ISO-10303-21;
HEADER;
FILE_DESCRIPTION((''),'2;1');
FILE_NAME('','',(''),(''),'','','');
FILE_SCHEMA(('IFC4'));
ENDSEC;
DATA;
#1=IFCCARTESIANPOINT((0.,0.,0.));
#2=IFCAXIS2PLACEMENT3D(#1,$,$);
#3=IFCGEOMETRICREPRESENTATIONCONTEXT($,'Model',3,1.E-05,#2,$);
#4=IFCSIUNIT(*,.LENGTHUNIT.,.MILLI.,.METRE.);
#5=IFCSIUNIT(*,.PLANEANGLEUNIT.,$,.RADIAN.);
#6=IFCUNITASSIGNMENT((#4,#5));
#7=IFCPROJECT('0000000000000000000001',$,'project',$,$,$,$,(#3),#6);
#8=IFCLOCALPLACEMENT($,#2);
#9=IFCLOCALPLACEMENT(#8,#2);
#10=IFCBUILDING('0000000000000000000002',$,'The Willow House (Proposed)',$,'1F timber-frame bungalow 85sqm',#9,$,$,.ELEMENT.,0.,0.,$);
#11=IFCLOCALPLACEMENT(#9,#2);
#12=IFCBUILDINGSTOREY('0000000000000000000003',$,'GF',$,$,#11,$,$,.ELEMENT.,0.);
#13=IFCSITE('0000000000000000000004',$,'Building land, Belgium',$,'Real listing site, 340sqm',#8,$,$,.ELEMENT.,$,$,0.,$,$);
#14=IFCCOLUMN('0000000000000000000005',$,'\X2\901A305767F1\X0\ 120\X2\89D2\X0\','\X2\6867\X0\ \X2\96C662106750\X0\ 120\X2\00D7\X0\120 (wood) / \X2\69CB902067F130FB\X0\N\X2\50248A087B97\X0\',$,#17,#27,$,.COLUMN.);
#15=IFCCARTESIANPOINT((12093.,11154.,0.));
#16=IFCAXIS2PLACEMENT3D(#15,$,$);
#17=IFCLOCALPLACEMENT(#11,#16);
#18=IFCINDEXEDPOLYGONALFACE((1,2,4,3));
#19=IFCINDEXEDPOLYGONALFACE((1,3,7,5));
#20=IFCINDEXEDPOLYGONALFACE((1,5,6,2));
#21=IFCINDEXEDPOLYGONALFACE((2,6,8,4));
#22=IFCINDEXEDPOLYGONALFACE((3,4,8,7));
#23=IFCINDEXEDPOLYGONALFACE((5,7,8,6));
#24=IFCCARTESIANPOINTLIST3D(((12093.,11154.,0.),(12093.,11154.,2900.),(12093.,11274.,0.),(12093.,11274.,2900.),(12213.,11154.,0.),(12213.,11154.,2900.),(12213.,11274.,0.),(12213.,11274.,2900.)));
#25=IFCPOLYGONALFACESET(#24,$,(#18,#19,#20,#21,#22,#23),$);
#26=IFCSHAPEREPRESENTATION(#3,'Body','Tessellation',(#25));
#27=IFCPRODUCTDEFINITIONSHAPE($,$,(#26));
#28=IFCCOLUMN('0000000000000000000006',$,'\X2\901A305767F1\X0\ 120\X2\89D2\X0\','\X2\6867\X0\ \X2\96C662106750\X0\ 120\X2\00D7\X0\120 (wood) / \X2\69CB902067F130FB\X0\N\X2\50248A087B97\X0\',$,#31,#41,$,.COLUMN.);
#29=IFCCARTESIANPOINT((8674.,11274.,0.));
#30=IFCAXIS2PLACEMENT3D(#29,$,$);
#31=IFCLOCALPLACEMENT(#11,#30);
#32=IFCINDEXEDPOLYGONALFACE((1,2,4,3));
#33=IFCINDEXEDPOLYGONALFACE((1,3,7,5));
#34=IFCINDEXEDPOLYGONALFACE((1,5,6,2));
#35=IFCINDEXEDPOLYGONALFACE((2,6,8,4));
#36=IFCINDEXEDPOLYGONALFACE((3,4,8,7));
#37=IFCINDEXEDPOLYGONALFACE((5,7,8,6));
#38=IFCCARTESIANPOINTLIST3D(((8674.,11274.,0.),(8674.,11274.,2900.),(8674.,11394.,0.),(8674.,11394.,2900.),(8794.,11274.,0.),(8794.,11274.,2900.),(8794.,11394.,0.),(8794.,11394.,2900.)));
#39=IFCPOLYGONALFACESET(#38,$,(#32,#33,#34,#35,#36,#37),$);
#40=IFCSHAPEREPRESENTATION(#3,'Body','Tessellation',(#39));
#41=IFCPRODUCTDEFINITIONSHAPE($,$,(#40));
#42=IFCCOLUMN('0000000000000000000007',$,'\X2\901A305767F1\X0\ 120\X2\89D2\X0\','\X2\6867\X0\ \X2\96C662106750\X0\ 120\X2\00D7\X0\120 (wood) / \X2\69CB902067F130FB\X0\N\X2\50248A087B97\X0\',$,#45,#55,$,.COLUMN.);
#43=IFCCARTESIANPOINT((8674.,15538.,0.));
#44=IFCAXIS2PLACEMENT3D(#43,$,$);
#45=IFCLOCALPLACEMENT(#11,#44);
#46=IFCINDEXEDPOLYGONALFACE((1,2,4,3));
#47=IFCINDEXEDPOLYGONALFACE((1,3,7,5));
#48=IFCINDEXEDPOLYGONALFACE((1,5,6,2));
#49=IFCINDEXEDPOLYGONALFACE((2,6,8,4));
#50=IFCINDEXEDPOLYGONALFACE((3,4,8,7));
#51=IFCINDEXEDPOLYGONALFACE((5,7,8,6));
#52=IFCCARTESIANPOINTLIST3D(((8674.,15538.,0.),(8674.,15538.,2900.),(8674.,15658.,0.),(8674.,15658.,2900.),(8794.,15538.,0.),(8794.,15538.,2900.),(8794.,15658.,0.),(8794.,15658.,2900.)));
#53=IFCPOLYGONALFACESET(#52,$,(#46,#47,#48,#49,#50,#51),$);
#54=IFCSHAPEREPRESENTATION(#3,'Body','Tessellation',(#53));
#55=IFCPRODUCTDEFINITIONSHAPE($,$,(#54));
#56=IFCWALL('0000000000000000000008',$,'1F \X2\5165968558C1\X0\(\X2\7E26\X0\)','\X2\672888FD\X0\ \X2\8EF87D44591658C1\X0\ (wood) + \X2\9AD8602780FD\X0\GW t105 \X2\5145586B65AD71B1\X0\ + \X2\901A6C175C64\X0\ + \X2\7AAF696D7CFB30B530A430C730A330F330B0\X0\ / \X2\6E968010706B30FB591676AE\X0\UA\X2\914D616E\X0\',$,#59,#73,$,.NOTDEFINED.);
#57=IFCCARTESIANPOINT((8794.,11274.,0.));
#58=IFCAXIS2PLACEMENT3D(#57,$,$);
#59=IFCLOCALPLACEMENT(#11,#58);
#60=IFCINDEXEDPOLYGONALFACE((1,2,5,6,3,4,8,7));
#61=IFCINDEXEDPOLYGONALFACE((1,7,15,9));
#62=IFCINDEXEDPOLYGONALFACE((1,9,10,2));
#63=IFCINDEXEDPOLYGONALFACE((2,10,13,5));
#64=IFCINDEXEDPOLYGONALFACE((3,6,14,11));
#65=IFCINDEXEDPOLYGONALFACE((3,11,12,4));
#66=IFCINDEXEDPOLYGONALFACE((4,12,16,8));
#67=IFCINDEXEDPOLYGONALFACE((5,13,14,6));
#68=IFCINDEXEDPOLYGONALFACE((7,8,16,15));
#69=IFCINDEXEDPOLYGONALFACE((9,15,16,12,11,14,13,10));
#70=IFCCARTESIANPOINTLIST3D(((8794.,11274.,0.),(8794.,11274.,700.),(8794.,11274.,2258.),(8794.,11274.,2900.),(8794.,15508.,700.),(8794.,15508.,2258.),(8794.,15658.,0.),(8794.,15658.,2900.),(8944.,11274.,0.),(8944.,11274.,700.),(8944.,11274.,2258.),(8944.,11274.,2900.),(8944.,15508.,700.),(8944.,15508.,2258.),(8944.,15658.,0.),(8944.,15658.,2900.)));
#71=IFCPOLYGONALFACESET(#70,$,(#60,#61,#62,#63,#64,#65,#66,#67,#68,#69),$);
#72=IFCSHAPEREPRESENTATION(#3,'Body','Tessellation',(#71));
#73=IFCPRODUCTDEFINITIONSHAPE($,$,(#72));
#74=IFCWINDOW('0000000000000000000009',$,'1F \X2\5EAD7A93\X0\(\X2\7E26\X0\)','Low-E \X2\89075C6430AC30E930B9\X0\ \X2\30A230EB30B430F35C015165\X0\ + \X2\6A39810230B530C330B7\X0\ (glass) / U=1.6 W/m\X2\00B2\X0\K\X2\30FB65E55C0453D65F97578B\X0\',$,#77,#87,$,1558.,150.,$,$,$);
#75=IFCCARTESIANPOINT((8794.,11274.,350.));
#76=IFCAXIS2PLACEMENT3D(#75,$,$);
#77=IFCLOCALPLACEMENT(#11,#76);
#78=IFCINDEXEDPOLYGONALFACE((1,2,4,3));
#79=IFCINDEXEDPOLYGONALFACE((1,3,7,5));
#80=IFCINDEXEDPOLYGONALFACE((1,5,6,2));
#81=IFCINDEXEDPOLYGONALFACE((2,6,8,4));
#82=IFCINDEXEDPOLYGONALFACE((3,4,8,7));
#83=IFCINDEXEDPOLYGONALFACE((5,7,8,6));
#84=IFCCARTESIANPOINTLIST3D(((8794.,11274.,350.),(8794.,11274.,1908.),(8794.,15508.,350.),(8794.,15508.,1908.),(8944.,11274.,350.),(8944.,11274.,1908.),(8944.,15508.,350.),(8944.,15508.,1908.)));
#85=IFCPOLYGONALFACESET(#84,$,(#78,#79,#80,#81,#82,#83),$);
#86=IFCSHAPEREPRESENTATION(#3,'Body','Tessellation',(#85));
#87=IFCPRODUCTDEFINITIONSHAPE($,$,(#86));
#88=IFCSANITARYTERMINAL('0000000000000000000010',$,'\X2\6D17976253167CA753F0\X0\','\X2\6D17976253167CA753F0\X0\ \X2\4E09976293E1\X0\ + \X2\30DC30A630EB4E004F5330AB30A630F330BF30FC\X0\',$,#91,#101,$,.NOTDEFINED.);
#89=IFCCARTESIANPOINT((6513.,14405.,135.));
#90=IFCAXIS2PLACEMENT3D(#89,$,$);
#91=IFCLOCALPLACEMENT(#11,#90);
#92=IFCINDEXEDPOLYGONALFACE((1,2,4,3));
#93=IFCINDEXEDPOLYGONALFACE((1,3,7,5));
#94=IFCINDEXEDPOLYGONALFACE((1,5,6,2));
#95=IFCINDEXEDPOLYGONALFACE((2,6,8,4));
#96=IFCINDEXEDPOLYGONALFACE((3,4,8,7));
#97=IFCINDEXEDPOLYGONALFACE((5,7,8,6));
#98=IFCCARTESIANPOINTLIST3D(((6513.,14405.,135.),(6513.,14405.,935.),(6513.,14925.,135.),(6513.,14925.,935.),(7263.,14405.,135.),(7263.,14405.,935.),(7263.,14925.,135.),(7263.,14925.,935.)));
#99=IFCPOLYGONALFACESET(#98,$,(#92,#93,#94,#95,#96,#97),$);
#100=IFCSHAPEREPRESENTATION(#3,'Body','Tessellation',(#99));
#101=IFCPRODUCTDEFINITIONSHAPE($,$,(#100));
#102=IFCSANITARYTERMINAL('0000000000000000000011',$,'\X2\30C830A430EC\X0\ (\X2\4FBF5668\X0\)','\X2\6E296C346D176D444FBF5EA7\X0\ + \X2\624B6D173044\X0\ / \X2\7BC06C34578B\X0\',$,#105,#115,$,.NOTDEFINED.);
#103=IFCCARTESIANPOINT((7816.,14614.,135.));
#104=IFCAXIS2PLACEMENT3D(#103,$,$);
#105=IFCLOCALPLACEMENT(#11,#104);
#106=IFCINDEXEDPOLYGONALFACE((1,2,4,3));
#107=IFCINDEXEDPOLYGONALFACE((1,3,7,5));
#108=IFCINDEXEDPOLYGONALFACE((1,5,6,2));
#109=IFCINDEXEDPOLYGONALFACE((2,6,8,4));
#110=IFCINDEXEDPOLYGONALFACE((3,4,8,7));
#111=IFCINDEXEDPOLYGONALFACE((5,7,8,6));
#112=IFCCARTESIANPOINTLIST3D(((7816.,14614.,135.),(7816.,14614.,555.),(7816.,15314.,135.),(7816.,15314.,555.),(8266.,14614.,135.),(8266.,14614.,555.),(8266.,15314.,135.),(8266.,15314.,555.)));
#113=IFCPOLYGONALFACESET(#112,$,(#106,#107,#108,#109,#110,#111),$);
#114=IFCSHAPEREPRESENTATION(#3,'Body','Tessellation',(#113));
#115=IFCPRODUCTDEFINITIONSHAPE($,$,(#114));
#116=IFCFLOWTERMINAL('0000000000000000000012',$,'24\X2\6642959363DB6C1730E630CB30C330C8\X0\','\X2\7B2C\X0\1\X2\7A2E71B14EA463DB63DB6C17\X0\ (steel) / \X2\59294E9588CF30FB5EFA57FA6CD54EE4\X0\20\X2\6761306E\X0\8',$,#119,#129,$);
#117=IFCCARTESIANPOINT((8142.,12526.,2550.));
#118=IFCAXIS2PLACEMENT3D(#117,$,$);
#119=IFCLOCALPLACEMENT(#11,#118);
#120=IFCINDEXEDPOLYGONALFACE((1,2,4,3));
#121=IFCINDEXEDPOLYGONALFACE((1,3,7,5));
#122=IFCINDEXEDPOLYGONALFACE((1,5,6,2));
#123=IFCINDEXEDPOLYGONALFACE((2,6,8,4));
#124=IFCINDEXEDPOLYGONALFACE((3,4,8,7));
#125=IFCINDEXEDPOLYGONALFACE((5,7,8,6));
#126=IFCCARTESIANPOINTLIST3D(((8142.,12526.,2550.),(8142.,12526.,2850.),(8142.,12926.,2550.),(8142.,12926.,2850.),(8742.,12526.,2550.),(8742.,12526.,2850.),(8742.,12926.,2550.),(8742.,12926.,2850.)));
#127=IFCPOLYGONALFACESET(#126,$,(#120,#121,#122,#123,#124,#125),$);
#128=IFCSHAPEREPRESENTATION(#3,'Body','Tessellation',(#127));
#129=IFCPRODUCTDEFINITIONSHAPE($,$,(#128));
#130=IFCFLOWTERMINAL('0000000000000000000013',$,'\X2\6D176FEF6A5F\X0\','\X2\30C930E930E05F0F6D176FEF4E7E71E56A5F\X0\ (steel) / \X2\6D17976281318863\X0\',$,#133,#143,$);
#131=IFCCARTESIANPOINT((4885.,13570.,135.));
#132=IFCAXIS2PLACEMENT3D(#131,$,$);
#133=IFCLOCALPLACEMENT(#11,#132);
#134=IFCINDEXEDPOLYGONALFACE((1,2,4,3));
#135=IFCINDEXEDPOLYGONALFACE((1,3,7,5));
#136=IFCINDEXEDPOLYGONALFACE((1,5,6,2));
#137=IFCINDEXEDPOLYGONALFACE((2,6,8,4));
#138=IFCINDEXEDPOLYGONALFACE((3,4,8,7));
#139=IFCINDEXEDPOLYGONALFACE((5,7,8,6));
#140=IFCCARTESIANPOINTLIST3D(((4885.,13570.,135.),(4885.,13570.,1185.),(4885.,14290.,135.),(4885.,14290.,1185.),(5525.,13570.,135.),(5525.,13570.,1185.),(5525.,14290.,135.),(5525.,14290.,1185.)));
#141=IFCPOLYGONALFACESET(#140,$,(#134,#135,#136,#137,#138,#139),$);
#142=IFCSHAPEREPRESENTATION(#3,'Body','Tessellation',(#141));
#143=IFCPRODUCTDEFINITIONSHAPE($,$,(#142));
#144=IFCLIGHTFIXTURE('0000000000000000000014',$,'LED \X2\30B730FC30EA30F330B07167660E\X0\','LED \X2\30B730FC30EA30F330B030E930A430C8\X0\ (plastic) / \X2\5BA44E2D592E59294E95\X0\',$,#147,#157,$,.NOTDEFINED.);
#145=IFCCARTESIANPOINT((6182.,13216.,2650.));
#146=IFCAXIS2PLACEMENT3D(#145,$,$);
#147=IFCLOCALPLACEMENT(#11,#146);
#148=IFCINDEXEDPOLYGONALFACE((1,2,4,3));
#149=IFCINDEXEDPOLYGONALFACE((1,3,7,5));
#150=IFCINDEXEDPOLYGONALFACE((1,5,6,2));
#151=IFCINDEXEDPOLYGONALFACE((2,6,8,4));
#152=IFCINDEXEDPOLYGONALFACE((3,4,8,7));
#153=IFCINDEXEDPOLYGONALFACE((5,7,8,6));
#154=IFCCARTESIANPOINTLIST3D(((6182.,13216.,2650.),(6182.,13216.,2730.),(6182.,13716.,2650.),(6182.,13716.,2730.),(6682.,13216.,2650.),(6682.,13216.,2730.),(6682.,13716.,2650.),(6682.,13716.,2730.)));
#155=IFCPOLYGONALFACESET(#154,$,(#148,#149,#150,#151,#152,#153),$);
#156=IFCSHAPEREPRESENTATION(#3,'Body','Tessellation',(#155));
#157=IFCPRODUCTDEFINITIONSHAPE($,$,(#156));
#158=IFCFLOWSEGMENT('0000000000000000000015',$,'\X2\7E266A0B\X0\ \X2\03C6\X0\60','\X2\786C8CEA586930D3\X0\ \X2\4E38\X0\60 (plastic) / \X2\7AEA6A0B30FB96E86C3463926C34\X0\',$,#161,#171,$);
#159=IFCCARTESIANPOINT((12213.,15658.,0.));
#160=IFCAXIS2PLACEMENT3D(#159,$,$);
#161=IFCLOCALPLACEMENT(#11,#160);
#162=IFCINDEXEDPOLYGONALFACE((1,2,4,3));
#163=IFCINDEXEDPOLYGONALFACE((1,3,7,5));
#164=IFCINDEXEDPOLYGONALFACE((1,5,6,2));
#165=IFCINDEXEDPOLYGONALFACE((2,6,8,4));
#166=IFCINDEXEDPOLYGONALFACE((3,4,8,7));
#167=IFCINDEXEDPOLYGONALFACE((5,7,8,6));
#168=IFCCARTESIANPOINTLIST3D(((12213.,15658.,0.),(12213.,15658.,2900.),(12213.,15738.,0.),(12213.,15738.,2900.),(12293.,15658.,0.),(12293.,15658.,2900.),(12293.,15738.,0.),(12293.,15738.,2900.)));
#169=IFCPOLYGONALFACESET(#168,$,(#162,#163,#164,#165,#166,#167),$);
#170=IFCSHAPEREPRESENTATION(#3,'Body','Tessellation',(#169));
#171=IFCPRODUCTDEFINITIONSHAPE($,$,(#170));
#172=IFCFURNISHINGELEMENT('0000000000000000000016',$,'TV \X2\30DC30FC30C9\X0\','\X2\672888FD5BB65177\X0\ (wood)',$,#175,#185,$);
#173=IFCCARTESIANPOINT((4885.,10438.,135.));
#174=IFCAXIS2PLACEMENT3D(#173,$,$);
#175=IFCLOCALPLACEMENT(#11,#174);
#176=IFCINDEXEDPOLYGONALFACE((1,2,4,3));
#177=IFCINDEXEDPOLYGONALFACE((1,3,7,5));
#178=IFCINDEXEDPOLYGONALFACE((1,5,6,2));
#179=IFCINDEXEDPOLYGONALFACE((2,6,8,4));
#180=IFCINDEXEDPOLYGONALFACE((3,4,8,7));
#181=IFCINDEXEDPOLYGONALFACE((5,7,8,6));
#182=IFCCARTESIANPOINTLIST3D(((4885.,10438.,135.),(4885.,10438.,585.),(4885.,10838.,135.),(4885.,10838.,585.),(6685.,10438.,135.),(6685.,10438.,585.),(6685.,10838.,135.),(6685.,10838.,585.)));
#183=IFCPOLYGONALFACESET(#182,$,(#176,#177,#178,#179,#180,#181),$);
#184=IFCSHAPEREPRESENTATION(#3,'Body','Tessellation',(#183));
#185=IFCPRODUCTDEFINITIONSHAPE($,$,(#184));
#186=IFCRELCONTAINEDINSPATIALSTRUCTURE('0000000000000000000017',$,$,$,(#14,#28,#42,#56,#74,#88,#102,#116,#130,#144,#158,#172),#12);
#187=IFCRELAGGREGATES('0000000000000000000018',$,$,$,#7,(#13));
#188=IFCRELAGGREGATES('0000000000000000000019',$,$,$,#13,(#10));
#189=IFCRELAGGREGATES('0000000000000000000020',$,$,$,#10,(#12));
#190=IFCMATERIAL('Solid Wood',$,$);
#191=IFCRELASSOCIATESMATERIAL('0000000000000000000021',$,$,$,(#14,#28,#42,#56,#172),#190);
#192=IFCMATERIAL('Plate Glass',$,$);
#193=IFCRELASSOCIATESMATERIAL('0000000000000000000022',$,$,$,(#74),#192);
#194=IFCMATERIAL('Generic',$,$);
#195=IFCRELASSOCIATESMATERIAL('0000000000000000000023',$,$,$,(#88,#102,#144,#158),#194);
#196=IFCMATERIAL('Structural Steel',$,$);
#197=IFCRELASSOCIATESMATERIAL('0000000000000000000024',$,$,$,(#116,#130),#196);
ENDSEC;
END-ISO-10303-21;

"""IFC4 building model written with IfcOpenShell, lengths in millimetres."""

from ifc_helpers import new_model, si_unit, frame, frame_2d, origin, place, context, project, spatial, rectangle, extrude, material, element, fill, save


model = new_model("IFC4")

# Units and contexts
model_context = context("Model", 3, precision=1e-05, world=origin())
ifc_project = project(units=[si_unit("LENGTHUNIT", "METRE", prefix="MILLI"), si_unit("PLANEANGLEUNIT", "RADIAN")], contexts=[model_context])

# Site, building, storey
site_placement = place(None, origin())
site = spatial("IfcSite", under=ifc_project, at=site_placement, Name="Building land, Belgium", ObjectType="Real listing site, 340sqm", CompositionType="ELEMENT", RefElevation=0.0)
building_placement = place(site_placement, origin())
building = spatial("IfcBuilding", under=site, at=building_placement, Name="The Willow House (Proposed)", ObjectType="1F timber-frame bungalow 85sqm", CompositionType="ELEMENT", ElevationOfRefHeight=0.0, ElevationOfTerrain=0.0)
storey_placement = place(building_placement, origin())
storey = spatial("IfcBuildingStorey", under=building, at=storey_placement, Name="GF", CompositionType="ELEMENT", Elevation=0.0)

# Columns
ifc_material_1 = material(Name="Solid Wood")
column_1_placement = place(storey_placement, frame((12093.0, 11154.0, 0.0)))
element("IfcColumn", 1, at=column_1_placement, inside=storey, material=ifc_material_1, Name="通し柱 120角", Description="桧 集成材 120×120 (wood) / 構造柱・N値計算", PredefinedType="COLUMN", context=model_context, shape_type="SweptSolid", body=[
    extrude(rectangle(XDim=120.0, YDim=120.0, at=frame_2d((60.0, 60.0))), frame((12093.0, 11154.0, 0.0)), (0.0, 0.0, 1.0), 2900.0),
])
column_2_placement = place(storey_placement, frame((8674.0, 11274.0, 0.0)))
element("IfcColumn", 2, at=column_2_placement, inside=storey, material=ifc_material_1, Name="通し柱 120角", Description="桧 集成材 120×120 (wood) / 構造柱・N値計算", PredefinedType="COLUMN", context=model_context, shape_type="SweptSolid", body=[
    extrude(rectangle(XDim=120.0, YDim=120.0, at=frame_2d((60.0, 60.0))), frame((8674.0, 11274.0, 0.0)), (0.0, 0.0, 1.0), 2900.0),
])
column_3_placement = place(storey_placement, frame((8674.0, 15538.0, 0.0)))
element("IfcColumn", 3, at=column_3_placement, inside=storey, material=ifc_material_1, Name="通し柱 120角", Description="桧 集成材 120×120 (wood) / 構造柱・N値計算", PredefinedType="COLUMN", context=model_context, shape_type="SweptSolid", body=[
    extrude(rectangle(XDim=120.0, YDim=120.0, at=frame_2d((60.0, 60.0))), frame((8674.0, 15538.0, 0.0)), (0.0, 0.0, 1.0), 2900.0),
])

# Wall, opening, window
wall_1_placement = place(storey_placement, frame((8794.0, 11274.0, 0.0)))
wall_1 = element("IfcWall", 4, at=wall_1_placement, inside=storey, material=ifc_material_1, Name="1F 入隅壁(縦)", Description="木製 軸組外壁 (wood) + 高性能GW t105 充填断熱 + 通気層 + 窯業系サイディング / 準耐火・外皮UA配慮", PredefinedType="NOTDEFINED", context=model_context, shape_type="SweptSolid", body=[
    extrude(rectangle(XDim=150.0, YDim=4384.0, at=frame_2d((75.0, 2192.0))), frame((8794.0, 11274.0, 0.0)), (0.0, 0.0, 1.0), 2900.0),
])
opening_placement = place(storey_placement, frame((8794.0, 11274.0, 350.0)))
opening = element("IfcOpeningElement", 5, at=opening_placement, cuts=wall_1, PredefinedType="NOTDEFINED", context=model_context, shape_type="SweptSolid", body=[
    extrude(rectangle(XDim=150.0, YDim=4234.0, at=frame_2d((75.0, 2117.0))), frame((8794.0, 11274.0, 350.0)), (0.0, 0.0, 1.0), 1558.0),
])
ifc_material_2 = material(Name="Plate Glass")
window_placement = place(storey_placement, frame((8794.0, 11274.0, 350.0)))
window = element("IfcWindow", 6, at=window_placement, inside=storey, material=ifc_material_2, Name="1F 庭窓(縦)", Description="Low-E 複層ガラス アルゴン封入 + 樹脂サッシ (glass) / U=1.6 W/m²K・日射取得型", OverallHeight=1558.0, OverallWidth=150.0, context=model_context, shape_type="SweptSolid", body=[
    extrude(rectangle(XDim=150.0, YDim=4234.0, at=frame_2d((75.0, 2117.0))), frame((8794.0, 11274.0, 350.0)), (0.0, 0.0, 1.0), 1558.0),
])
fill(opening, window)

# Sanitary terminals
ifc_material_3 = material(Name="Generic")
sanitary_terminal_1_placement = place(storey_placement, frame((6513.0, 14405.0, 135.0)))
element("IfcSanitaryTerminal", 7, at=sanitary_terminal_1_placement, inside=storey, material=ifc_material_3, Name="洗面化粧台", Description="洗面化粧台 三面鏡 + ボウル一体カウンター", PredefinedType="NOTDEFINED", context=model_context, shape_type="SweptSolid", body=[
    extrude(rectangle(XDim=750.0, YDim=520.0, at=frame_2d((375.0, 260.0))), frame((6513.0, 14405.0, 135.0)), (0.0, 0.0, 1.0), 800.0),
])
sanitary_terminal_2_placement = place(storey_placement, frame((7816.0, 14614.0, 135.0)))
element("IfcSanitaryTerminal", 8, at=sanitary_terminal_2_placement, inside=storey, material=ifc_material_3, Name="トイレ (便器)", Description="温水洗浄便座 + 手洗い / 節水型", PredefinedType="NOTDEFINED", context=model_context, shape_type="SweptSolid", body=[
    extrude(rectangle(XDim=450.0, YDim=700.0, at=frame_2d((225.0, 350.0))), frame((7816.0, 14614.0, 135.0)), (0.0, 0.0, 1.0), 420.0),
])

# Flow terminals
ifc_material_4 = material(Name="Structural Steel")
flow_terminal_1_placement = place(storey_placement, frame((8142.0, 12526.0, 2550.0)))
element("IfcFlowTerminal", 9, at=flow_terminal_1_placement, inside=storey, material=ifc_material_4, Name="24時間換気ユニット", Description="第1種熱交換換気 (steel) / 天井裏・建基法令20条の8", context=model_context, shape_type="SweptSolid", body=[
    extrude(rectangle(XDim=600.0, YDim=400.0, at=frame_2d((300.0, 200.0))), frame((8142.0, 12526.0, 2550.0)), (0.0, 0.0, 1.0), 300.0),
])
flow_terminal_2_placement = place(storey_placement, frame((4885.0, 13570.0, 135.0)))
element("IfcFlowTerminal", 10, at=flow_terminal_2_placement, inside=storey, material=ifc_material_4, Name="洗濯機", Description="ドラム式洗濯乾燥機 (steel) / 洗面脱衣", context=model_context, shape_type="SweptSolid", body=[
    extrude(rectangle(XDim=640.0, YDim=720.0, at=frame_2d((320.0, 360.0))), frame((4885.0, 13570.0, 135.0)), (0.0, 0.0, 1.0), 1050.0),
])

# Light fixture
light_fixture_placement = place(storey_placement, frame((6182.0, 13216.0, 2650.0)))
element("IfcLightFixture", 11, at=light_fixture_placement, inside=storey, material=ifc_material_3, Name="LED シーリング照明", Description="LED シーリングライト (plastic) / 室中央天井", PredefinedType="NOTDEFINED", context=model_context, shape_type="SweptSolid", body=[
    extrude(rectangle(XDim=500.0, YDim=500.0, at=frame_2d((250.0, 250.0))), frame((6182.0, 13216.0, 2650.0)), (0.0, 0.0, 1.0), 80.0),
])

# Flow segment
flow_segment_placement = place(storey_placement, frame((12213.0, 15658.0, 0.0)))
element("IfcFlowSegment", 12, at=flow_segment_placement, inside=storey, material=ifc_material_3, Name="縦樋 φ60", Description="硬質塩ビ 丸60 (plastic) / 竪樋・雨水排水", context=model_context, shape_type="SweptSolid", body=[
    extrude(rectangle(XDim=80.0, YDim=80.0, at=frame_2d((40.0, 40.0))), frame((12213.0, 15658.0, 0.0)), (0.0, 0.0, 1.0), 2900.0),
])

# Furnishing element
furnishing_placement = place(storey_placement, frame((4885.0, 10438.0, 135.0)))
element("IfcFurnishingElement", 13, at=furnishing_placement, inside=storey, material=ifc_material_1, Name="TV ボード", Description="木製家具 (wood)", context=model_context, shape_type="SweptSolid", body=[
    extrude(rectangle(XDim=1800.0, YDim=400.0, at=frame_2d((900.0, 200.0))), frame((4885.0, 10438.0, 135.0)), (0.0, 0.0, 1.0), 450.0),
])

save(model, "model.ifc")
